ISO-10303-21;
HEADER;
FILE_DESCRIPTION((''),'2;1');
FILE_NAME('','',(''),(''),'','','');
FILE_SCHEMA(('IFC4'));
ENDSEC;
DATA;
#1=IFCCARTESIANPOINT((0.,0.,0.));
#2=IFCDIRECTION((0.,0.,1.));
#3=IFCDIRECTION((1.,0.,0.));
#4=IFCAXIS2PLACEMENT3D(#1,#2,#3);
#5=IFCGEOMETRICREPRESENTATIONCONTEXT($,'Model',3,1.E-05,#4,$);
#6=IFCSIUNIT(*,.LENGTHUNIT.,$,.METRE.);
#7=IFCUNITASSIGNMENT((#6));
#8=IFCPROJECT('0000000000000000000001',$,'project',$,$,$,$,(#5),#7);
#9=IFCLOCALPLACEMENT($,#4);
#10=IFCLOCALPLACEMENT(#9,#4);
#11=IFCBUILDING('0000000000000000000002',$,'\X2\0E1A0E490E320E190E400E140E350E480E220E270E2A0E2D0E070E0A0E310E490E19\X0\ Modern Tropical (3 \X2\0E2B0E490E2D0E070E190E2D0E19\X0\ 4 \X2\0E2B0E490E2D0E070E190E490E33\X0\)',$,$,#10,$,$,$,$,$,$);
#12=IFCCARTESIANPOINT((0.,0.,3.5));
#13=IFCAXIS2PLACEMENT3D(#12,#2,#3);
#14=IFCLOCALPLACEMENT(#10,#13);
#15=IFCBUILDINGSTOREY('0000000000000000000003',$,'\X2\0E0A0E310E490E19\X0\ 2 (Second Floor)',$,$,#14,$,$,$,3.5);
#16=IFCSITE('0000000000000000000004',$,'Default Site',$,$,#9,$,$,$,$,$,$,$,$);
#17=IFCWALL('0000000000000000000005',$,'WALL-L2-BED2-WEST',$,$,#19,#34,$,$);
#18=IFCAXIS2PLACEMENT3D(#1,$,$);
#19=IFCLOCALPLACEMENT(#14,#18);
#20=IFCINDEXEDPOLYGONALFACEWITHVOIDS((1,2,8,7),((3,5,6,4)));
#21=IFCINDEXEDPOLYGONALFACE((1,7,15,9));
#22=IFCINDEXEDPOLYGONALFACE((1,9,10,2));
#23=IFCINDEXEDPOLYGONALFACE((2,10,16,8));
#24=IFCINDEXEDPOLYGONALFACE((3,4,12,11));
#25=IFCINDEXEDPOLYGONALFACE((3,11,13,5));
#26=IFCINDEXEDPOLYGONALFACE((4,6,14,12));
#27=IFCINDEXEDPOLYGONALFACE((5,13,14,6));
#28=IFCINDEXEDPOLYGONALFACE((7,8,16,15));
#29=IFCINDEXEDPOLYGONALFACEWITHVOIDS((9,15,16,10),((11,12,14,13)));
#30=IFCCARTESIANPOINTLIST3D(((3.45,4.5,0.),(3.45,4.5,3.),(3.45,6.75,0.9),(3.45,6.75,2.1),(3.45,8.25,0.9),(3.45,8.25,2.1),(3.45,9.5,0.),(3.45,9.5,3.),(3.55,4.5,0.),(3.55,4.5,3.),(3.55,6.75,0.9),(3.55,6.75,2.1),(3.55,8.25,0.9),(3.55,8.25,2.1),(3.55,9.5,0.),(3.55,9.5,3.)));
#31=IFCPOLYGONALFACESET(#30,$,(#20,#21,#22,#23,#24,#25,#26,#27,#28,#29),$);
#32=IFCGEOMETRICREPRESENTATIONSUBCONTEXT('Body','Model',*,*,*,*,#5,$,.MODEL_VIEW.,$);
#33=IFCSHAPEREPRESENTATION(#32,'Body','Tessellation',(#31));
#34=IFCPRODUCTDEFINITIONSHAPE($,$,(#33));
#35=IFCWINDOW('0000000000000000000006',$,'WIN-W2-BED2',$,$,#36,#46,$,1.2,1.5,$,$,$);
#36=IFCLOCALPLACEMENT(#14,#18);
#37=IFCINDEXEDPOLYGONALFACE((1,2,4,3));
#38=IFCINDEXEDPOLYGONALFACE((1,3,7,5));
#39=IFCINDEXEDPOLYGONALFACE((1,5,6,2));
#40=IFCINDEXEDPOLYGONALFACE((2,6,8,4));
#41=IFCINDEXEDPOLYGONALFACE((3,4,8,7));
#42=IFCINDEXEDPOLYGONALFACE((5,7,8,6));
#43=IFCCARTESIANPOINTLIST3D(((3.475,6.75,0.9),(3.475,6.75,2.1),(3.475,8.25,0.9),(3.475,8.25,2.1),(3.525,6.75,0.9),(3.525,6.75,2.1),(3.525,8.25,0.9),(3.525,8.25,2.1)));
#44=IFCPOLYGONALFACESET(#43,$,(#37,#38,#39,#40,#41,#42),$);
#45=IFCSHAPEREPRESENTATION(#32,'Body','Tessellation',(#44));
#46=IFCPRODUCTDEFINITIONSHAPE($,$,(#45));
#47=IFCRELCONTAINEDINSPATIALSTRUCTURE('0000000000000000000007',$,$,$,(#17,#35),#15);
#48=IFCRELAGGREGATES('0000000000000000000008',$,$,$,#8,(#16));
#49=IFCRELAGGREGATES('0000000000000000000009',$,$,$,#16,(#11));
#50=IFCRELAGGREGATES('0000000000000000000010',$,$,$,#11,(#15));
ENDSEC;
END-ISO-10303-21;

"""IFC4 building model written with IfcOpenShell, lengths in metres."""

from ifc_helpers import new_model, si_unit, frame, origin_with_axes, origin_2d, place, context, subcontext, project, spatial, rectangle, extrude, element, fill, save


model = new_model("IFC4")

# Units and contexts
model_context = context("Model", 3, precision=1e-05, world=origin_with_axes())
body_context = subcontext(model_context, "Body", "Model", "MODEL_VIEW")
ifc_project = project(units=[si_unit("LENGTHUNIT", "METRE")], contexts=[model_context])

# Site, building, storey
site_placement = place(None, origin_with_axes())
site = spatial("IfcSite", under=ifc_project, at=site_placement, Name="Default Site")
building_placement = place(site_placement, origin_with_axes())
building = spatial("IfcBuilding", under=site, at=building_placement, Name="บ้านเดี่ยวสองชั้น Modern Tropical (3 ห้องนอน 4 ห้องน้ำ)")
storey_placement = place(building_placement, frame((0.0, 0.0, 3.5), z_axis=(0.0, 0.0, 1.0), x_axis=(1.0, 0.0, 0.0)))
storey = spatial("IfcBuildingStorey", under=building, at=storey_placement, Name="ชั้น 2 (Second Floor)", Elevation=3.5)

# Wall, opening, window
wall_1_placement = place(storey_placement, frame((3.5, 7.0, 0.0), z_axis=(0.0, 0.0, 1.0), x_axis=(0.0, 1.0, 0.0)))
wall_1 = element("IfcWall", 1, at=wall_1_placement, inside=storey, Name="WALL-L2-BED2-WEST", context=body_context, shape_type="SweptSolid", body=[
    extrude(rectangle(XDim=5.0, YDim=0.1, at=origin_2d()), origin_with_axes(), (0.0, 0.0, 1.0), 3.0),
])
opening_1_placement = place(wall_1_placement, frame((0.5, 0.0, 0.9), z_axis=(0.0, 0.0, 1.0), x_axis=(1.0, 0.0, 0.0)))
opening_1 = element("IfcOpeningElement", 2, at=opening_1_placement, cuts=wall_1, context=body_context, shape_type="SweptSolid", body=[
    extrude(rectangle(XDim=1.5, YDim=0.12, at=origin_2d()), origin_with_axes(), (0.0, 0.0, 1.0), 1.2),
])
window_placement = place(opening_1_placement, origin_with_axes())
window = element("IfcWindow", 3, at=window_placement, inside=storey, Name="WIN-W2-BED2", OverallHeight=1.2, OverallWidth=1.5, context=body_context, shape_type="SweptSolid", body=[
    extrude(rectangle(XDim=1.5, YDim=0.05, at=origin_2d()), origin_with_axes(), (0.0, 0.0, 1.0), 1.2),
])
fill(opening_1, window)

save(model, "model.ifc")
